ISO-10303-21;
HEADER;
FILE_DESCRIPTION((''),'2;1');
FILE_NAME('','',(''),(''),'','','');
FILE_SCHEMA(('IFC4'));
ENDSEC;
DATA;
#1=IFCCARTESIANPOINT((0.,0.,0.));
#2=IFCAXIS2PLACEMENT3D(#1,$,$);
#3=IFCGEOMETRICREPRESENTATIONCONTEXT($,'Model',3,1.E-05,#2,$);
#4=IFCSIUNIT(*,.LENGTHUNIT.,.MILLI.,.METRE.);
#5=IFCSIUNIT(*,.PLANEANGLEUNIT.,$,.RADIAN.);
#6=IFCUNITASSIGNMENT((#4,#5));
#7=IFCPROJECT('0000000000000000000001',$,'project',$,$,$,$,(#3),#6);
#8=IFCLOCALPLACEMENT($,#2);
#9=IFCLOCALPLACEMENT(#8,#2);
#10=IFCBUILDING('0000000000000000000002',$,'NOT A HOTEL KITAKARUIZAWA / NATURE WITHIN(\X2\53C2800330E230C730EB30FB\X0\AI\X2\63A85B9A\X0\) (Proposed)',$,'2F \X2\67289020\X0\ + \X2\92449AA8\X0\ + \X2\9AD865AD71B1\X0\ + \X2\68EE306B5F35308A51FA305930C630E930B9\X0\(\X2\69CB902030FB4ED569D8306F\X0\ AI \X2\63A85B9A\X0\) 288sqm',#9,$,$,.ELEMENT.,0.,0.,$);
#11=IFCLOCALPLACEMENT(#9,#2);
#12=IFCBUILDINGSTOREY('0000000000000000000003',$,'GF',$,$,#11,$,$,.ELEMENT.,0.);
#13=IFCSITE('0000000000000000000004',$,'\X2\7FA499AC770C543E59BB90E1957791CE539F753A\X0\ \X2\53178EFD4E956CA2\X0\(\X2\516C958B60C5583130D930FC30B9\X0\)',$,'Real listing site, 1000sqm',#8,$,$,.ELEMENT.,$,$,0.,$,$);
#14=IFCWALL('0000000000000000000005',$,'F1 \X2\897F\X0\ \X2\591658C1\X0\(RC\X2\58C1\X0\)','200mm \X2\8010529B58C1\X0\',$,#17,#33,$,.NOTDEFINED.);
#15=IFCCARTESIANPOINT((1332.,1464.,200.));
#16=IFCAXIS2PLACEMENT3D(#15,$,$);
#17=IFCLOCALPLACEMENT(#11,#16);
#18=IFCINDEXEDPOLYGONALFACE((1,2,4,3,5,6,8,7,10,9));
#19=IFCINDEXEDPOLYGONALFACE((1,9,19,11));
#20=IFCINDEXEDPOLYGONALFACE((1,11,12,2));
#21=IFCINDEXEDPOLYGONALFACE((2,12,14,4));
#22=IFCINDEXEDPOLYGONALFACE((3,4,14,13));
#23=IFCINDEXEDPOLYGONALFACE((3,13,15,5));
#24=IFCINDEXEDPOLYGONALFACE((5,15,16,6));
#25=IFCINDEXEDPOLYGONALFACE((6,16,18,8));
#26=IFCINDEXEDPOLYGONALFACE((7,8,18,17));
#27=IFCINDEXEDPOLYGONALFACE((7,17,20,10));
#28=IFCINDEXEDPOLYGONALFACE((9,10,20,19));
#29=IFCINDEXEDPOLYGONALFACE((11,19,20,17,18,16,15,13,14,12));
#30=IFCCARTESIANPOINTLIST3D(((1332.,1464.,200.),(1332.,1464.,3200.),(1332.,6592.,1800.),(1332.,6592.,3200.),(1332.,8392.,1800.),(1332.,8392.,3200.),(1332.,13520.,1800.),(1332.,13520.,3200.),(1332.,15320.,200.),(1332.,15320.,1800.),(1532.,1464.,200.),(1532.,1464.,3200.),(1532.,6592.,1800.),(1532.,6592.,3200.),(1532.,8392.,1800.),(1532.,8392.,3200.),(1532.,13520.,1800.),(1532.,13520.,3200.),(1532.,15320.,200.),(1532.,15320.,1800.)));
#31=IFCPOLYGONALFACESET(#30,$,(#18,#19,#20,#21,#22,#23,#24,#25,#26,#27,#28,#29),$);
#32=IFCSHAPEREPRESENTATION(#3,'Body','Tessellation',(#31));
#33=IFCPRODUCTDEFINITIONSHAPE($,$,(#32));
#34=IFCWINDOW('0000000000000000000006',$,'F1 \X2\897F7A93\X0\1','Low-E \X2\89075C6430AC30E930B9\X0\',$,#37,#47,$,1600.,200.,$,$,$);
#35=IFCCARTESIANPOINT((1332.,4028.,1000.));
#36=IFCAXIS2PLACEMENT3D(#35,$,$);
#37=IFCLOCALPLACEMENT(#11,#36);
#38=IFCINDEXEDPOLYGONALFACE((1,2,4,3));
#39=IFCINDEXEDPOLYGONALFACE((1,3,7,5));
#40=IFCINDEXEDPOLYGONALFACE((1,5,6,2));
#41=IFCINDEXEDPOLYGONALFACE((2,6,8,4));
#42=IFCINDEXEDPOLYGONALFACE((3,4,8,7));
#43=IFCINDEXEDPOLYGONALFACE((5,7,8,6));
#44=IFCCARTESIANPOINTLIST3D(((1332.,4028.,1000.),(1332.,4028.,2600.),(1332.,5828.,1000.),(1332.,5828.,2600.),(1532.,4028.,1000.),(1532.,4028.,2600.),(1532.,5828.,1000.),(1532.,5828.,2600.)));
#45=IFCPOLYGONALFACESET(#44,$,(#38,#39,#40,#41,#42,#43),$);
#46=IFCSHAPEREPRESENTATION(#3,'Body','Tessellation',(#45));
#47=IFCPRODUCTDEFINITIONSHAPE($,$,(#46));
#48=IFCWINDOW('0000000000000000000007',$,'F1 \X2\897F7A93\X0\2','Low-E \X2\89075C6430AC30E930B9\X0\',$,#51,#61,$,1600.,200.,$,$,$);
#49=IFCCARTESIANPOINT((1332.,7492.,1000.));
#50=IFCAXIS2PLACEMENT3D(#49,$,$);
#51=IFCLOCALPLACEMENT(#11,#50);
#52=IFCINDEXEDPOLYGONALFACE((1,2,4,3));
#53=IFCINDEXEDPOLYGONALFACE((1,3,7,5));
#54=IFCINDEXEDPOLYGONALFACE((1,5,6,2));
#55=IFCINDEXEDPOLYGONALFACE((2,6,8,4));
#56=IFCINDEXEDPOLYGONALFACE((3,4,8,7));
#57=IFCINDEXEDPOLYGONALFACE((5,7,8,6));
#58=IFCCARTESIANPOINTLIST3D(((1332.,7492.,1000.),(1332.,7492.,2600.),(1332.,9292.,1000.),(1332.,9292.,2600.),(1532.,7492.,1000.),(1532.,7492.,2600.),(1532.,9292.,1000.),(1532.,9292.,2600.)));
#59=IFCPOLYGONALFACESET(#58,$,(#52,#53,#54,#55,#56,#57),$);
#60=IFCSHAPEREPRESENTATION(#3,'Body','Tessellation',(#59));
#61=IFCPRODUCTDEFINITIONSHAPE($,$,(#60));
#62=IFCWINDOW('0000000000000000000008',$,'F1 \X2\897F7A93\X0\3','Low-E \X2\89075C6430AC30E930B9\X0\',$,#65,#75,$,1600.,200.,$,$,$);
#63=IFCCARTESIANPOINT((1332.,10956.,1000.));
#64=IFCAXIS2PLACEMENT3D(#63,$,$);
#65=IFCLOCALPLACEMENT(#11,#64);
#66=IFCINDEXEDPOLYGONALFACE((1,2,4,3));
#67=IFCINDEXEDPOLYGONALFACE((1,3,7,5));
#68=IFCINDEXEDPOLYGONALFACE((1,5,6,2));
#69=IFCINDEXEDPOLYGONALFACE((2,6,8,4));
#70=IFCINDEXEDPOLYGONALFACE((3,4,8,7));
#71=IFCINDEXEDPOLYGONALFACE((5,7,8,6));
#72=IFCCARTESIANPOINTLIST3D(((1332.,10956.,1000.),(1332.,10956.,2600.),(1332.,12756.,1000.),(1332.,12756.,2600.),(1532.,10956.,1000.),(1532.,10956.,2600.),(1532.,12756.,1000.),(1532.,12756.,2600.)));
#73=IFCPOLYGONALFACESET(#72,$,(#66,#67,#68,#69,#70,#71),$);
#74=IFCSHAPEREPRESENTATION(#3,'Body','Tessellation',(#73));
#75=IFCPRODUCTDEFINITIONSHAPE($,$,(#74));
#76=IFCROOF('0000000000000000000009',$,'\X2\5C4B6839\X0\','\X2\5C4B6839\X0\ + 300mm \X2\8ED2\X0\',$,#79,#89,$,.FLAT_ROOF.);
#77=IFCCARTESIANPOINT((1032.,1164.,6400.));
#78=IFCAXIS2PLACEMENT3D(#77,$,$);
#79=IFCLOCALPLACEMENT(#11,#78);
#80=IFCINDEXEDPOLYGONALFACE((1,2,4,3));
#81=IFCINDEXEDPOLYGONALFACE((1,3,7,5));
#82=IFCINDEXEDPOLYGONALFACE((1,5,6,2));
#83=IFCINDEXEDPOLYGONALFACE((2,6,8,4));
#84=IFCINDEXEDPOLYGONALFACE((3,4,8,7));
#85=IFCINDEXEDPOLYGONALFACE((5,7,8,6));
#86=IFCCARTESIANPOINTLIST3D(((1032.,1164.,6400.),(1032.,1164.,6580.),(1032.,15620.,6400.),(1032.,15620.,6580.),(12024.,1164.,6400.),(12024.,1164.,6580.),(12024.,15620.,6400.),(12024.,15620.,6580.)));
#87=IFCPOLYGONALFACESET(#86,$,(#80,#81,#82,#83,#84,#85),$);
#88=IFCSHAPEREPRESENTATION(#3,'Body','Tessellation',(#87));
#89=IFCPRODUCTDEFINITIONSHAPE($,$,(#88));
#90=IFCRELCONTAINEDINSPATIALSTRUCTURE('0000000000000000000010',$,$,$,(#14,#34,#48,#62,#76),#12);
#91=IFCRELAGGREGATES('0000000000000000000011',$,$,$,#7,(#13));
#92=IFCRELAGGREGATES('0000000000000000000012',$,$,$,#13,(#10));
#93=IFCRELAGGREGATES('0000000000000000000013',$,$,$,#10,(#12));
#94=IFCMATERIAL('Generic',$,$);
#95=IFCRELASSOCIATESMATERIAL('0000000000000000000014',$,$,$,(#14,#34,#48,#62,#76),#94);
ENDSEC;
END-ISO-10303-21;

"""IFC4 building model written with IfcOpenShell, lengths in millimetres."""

from ifc_helpers import new_model, si_unit, frame, frame_2d, origin, place, context, project, spatial, rectangle, extrude, material, element, fill, save


model = new_model("IFC4")

# Units and contexts
model_context = context("Model", 3, precision=1e-05, world=origin())
ifc_project = project(units=[si_unit("LENGTHUNIT", "METRE", prefix="MILLI"), si_unit("PLANEANGLEUNIT", "RADIAN")], contexts=[model_context])

# Site, building, storey
site_placement = place(None, origin())
site = spatial("IfcSite", under=ifc_project, at=site_placement, Name="群馬県吾妻郡長野原町 北軽井沢(公開情報ベース)", ObjectType="Real listing site, 1000sqm", CompositionType="ELEMENT", RefElevation=0.0)
building_placement = place(site_placement, origin())
building = spatial("IfcBuilding", under=site, at=building_placement, Name="NOT A HOTEL KITAKARUIZAWA / NATURE WITHIN(参考モデル・AI推定) (Proposed)", ObjectType="2F 木造 + 鉄骨 + 高断熱 + 森に張り出すテラス(構造・仕様は AI 推定) 288sqm", CompositionType="ELEMENT", ElevationOfRefHeight=0.0, ElevationOfTerrain=0.0)
storey_placement = place(building_placement, origin())
storey = spatial("IfcBuildingStorey", under=building, at=storey_placement, Name="GF", CompositionType="ELEMENT", Elevation=0.0)

# Shared definitions
ifc_material_1 = material(Name="Generic")

# Wall, openings, windows
wall_1_placement = place(storey_placement, frame((1332.0, 1464.0, 200.0)))
wall_1 = element("IfcWall", 1, at=wall_1_placement, inside=storey, material=ifc_material_1, Name="F1 西 外壁(RC壁)", Description="200mm 耐力壁", PredefinedType="NOTDEFINED", context=model_context, shape_type="SweptSolid", body=[
    extrude(rectangle(XDim=200.0, YDim=13856.0, at=frame_2d((100.0, 6928.0))), frame((1332.0, 1464.0, 200.0)), (0.0, 0.0, 1.0), 3000.0),
])
opening_1_placement = place(storey_placement, frame((1332.0, 4028.0, 1000.0)))
opening_1 = element("IfcOpeningElement", 2, at=opening_1_placement, cuts=wall_1, PredefinedType="NOTDEFINED", context=model_context, shape_type="SweptSolid", body=[
    extrude(rectangle(XDim=200.0, YDim=1800.0, at=frame_2d((100.0, 900.0))), frame((1332.0, 4028.0, 1000.0)), (0.0, 0.0, 1.0), 1600.0),
])
opening_2_placement = place(storey_placement, frame((1332.0, 7492.0, 1000.0)))
opening_2 = element("IfcOpeningElement", 3, at=opening_2_placement, cuts=wall_1, PredefinedType="NOTDEFINED", context=model_context, shape_type="SweptSolid", body=[
    extrude(rectangle(XDim=200.0, YDim=1800.0, at=frame_2d((100.0, 900.0))), frame((1332.0, 7492.0, 1000.0)), (0.0, 0.0, 1.0), 1600.0),
])
opening_3_placement = place(storey_placement, frame((1332.0, 10956.0, 1000.0)))
opening_3 = element("IfcOpeningElement", 4, at=opening_3_placement, cuts=wall_1, PredefinedType="NOTDEFINED", context=model_context, shape_type="SweptSolid", body=[
    extrude(rectangle(XDim=200.0, YDim=1800.0, at=frame_2d((100.0, 900.0))), frame((1332.0, 10956.0, 1000.0)), (0.0, 0.0, 1.0), 1600.0),
])
window_1_placement = place(storey_placement, frame((1332.0, 4028.0, 1000.0)))
window_1 = element("IfcWindow", 5, at=window_1_placement, inside=storey, material=ifc_material_1, Name="F1 西窓1", Description="Low-E 複層ガラス", OverallHeight=1600.0, OverallWidth=200.0, context=model_context, shape_type="SweptSolid", body=[
    extrude(rectangle(XDim=200.0, YDim=1800.0, at=frame_2d((100.0, 900.0))), frame((1332.0, 4028.0, 1000.0)), (0.0, 0.0, 1.0), 1600.0),
])
fill(opening_1, window_1)
window_2_placement = place(storey_placement, frame((1332.0, 7492.0, 1000.0)))
window_2 = element("IfcWindow", 6, at=window_2_placement, inside=storey, material=ifc_material_1, Name="F1 西窓2", Description="Low-E 複層ガラス", OverallHeight=1600.0, OverallWidth=200.0, context=model_context, shape_type="SweptSolid", body=[
    extrude(rectangle(XDim=200.0, YDim=1800.0, at=frame_2d((100.0, 900.0))), frame((1332.0, 7492.0, 1000.0)), (0.0, 0.0, 1.0), 1600.0),
])
fill(opening_2, window_2)
window_3_placement = place(storey_placement, frame((1332.0, 10956.0, 1000.0)))
window_3 = element("IfcWindow", 7, at=window_3_placement, inside=storey, material=ifc_material_1, Name="F1 西窓3", Description="Low-E 複層ガラス", OverallHeight=1600.0, OverallWidth=200.0, context=model_context, shape_type="SweptSolid", body=[
    extrude(rectangle(XDim=200.0, YDim=1800.0, at=frame_2d((100.0, 900.0))), frame((1332.0, 10956.0, 1000.0)), (0.0, 0.0, 1.0), 1600.0),
])
fill(opening_3, window_3)

# Roof
roof_placement = place(storey_placement, frame((1032.0, 1164.0, 6400.0)))
element("IfcRoof", 8, at=roof_placement, inside=storey, material=ifc_material_1, Name="屋根", Description="屋根 + 300mm 軒", PredefinedType="FLAT_ROOF", context=model_context, shape_type="SweptSolid", body=[
    extrude(rectangle(XDim=10992.0, YDim=14456.0, at=frame_2d((5496.0, 7228.0))), frame((1032.0, 1164.0, 6400.0)), (0.0, 0.0, 1.0), 180.0),
])

save(model, "model.ifc")
